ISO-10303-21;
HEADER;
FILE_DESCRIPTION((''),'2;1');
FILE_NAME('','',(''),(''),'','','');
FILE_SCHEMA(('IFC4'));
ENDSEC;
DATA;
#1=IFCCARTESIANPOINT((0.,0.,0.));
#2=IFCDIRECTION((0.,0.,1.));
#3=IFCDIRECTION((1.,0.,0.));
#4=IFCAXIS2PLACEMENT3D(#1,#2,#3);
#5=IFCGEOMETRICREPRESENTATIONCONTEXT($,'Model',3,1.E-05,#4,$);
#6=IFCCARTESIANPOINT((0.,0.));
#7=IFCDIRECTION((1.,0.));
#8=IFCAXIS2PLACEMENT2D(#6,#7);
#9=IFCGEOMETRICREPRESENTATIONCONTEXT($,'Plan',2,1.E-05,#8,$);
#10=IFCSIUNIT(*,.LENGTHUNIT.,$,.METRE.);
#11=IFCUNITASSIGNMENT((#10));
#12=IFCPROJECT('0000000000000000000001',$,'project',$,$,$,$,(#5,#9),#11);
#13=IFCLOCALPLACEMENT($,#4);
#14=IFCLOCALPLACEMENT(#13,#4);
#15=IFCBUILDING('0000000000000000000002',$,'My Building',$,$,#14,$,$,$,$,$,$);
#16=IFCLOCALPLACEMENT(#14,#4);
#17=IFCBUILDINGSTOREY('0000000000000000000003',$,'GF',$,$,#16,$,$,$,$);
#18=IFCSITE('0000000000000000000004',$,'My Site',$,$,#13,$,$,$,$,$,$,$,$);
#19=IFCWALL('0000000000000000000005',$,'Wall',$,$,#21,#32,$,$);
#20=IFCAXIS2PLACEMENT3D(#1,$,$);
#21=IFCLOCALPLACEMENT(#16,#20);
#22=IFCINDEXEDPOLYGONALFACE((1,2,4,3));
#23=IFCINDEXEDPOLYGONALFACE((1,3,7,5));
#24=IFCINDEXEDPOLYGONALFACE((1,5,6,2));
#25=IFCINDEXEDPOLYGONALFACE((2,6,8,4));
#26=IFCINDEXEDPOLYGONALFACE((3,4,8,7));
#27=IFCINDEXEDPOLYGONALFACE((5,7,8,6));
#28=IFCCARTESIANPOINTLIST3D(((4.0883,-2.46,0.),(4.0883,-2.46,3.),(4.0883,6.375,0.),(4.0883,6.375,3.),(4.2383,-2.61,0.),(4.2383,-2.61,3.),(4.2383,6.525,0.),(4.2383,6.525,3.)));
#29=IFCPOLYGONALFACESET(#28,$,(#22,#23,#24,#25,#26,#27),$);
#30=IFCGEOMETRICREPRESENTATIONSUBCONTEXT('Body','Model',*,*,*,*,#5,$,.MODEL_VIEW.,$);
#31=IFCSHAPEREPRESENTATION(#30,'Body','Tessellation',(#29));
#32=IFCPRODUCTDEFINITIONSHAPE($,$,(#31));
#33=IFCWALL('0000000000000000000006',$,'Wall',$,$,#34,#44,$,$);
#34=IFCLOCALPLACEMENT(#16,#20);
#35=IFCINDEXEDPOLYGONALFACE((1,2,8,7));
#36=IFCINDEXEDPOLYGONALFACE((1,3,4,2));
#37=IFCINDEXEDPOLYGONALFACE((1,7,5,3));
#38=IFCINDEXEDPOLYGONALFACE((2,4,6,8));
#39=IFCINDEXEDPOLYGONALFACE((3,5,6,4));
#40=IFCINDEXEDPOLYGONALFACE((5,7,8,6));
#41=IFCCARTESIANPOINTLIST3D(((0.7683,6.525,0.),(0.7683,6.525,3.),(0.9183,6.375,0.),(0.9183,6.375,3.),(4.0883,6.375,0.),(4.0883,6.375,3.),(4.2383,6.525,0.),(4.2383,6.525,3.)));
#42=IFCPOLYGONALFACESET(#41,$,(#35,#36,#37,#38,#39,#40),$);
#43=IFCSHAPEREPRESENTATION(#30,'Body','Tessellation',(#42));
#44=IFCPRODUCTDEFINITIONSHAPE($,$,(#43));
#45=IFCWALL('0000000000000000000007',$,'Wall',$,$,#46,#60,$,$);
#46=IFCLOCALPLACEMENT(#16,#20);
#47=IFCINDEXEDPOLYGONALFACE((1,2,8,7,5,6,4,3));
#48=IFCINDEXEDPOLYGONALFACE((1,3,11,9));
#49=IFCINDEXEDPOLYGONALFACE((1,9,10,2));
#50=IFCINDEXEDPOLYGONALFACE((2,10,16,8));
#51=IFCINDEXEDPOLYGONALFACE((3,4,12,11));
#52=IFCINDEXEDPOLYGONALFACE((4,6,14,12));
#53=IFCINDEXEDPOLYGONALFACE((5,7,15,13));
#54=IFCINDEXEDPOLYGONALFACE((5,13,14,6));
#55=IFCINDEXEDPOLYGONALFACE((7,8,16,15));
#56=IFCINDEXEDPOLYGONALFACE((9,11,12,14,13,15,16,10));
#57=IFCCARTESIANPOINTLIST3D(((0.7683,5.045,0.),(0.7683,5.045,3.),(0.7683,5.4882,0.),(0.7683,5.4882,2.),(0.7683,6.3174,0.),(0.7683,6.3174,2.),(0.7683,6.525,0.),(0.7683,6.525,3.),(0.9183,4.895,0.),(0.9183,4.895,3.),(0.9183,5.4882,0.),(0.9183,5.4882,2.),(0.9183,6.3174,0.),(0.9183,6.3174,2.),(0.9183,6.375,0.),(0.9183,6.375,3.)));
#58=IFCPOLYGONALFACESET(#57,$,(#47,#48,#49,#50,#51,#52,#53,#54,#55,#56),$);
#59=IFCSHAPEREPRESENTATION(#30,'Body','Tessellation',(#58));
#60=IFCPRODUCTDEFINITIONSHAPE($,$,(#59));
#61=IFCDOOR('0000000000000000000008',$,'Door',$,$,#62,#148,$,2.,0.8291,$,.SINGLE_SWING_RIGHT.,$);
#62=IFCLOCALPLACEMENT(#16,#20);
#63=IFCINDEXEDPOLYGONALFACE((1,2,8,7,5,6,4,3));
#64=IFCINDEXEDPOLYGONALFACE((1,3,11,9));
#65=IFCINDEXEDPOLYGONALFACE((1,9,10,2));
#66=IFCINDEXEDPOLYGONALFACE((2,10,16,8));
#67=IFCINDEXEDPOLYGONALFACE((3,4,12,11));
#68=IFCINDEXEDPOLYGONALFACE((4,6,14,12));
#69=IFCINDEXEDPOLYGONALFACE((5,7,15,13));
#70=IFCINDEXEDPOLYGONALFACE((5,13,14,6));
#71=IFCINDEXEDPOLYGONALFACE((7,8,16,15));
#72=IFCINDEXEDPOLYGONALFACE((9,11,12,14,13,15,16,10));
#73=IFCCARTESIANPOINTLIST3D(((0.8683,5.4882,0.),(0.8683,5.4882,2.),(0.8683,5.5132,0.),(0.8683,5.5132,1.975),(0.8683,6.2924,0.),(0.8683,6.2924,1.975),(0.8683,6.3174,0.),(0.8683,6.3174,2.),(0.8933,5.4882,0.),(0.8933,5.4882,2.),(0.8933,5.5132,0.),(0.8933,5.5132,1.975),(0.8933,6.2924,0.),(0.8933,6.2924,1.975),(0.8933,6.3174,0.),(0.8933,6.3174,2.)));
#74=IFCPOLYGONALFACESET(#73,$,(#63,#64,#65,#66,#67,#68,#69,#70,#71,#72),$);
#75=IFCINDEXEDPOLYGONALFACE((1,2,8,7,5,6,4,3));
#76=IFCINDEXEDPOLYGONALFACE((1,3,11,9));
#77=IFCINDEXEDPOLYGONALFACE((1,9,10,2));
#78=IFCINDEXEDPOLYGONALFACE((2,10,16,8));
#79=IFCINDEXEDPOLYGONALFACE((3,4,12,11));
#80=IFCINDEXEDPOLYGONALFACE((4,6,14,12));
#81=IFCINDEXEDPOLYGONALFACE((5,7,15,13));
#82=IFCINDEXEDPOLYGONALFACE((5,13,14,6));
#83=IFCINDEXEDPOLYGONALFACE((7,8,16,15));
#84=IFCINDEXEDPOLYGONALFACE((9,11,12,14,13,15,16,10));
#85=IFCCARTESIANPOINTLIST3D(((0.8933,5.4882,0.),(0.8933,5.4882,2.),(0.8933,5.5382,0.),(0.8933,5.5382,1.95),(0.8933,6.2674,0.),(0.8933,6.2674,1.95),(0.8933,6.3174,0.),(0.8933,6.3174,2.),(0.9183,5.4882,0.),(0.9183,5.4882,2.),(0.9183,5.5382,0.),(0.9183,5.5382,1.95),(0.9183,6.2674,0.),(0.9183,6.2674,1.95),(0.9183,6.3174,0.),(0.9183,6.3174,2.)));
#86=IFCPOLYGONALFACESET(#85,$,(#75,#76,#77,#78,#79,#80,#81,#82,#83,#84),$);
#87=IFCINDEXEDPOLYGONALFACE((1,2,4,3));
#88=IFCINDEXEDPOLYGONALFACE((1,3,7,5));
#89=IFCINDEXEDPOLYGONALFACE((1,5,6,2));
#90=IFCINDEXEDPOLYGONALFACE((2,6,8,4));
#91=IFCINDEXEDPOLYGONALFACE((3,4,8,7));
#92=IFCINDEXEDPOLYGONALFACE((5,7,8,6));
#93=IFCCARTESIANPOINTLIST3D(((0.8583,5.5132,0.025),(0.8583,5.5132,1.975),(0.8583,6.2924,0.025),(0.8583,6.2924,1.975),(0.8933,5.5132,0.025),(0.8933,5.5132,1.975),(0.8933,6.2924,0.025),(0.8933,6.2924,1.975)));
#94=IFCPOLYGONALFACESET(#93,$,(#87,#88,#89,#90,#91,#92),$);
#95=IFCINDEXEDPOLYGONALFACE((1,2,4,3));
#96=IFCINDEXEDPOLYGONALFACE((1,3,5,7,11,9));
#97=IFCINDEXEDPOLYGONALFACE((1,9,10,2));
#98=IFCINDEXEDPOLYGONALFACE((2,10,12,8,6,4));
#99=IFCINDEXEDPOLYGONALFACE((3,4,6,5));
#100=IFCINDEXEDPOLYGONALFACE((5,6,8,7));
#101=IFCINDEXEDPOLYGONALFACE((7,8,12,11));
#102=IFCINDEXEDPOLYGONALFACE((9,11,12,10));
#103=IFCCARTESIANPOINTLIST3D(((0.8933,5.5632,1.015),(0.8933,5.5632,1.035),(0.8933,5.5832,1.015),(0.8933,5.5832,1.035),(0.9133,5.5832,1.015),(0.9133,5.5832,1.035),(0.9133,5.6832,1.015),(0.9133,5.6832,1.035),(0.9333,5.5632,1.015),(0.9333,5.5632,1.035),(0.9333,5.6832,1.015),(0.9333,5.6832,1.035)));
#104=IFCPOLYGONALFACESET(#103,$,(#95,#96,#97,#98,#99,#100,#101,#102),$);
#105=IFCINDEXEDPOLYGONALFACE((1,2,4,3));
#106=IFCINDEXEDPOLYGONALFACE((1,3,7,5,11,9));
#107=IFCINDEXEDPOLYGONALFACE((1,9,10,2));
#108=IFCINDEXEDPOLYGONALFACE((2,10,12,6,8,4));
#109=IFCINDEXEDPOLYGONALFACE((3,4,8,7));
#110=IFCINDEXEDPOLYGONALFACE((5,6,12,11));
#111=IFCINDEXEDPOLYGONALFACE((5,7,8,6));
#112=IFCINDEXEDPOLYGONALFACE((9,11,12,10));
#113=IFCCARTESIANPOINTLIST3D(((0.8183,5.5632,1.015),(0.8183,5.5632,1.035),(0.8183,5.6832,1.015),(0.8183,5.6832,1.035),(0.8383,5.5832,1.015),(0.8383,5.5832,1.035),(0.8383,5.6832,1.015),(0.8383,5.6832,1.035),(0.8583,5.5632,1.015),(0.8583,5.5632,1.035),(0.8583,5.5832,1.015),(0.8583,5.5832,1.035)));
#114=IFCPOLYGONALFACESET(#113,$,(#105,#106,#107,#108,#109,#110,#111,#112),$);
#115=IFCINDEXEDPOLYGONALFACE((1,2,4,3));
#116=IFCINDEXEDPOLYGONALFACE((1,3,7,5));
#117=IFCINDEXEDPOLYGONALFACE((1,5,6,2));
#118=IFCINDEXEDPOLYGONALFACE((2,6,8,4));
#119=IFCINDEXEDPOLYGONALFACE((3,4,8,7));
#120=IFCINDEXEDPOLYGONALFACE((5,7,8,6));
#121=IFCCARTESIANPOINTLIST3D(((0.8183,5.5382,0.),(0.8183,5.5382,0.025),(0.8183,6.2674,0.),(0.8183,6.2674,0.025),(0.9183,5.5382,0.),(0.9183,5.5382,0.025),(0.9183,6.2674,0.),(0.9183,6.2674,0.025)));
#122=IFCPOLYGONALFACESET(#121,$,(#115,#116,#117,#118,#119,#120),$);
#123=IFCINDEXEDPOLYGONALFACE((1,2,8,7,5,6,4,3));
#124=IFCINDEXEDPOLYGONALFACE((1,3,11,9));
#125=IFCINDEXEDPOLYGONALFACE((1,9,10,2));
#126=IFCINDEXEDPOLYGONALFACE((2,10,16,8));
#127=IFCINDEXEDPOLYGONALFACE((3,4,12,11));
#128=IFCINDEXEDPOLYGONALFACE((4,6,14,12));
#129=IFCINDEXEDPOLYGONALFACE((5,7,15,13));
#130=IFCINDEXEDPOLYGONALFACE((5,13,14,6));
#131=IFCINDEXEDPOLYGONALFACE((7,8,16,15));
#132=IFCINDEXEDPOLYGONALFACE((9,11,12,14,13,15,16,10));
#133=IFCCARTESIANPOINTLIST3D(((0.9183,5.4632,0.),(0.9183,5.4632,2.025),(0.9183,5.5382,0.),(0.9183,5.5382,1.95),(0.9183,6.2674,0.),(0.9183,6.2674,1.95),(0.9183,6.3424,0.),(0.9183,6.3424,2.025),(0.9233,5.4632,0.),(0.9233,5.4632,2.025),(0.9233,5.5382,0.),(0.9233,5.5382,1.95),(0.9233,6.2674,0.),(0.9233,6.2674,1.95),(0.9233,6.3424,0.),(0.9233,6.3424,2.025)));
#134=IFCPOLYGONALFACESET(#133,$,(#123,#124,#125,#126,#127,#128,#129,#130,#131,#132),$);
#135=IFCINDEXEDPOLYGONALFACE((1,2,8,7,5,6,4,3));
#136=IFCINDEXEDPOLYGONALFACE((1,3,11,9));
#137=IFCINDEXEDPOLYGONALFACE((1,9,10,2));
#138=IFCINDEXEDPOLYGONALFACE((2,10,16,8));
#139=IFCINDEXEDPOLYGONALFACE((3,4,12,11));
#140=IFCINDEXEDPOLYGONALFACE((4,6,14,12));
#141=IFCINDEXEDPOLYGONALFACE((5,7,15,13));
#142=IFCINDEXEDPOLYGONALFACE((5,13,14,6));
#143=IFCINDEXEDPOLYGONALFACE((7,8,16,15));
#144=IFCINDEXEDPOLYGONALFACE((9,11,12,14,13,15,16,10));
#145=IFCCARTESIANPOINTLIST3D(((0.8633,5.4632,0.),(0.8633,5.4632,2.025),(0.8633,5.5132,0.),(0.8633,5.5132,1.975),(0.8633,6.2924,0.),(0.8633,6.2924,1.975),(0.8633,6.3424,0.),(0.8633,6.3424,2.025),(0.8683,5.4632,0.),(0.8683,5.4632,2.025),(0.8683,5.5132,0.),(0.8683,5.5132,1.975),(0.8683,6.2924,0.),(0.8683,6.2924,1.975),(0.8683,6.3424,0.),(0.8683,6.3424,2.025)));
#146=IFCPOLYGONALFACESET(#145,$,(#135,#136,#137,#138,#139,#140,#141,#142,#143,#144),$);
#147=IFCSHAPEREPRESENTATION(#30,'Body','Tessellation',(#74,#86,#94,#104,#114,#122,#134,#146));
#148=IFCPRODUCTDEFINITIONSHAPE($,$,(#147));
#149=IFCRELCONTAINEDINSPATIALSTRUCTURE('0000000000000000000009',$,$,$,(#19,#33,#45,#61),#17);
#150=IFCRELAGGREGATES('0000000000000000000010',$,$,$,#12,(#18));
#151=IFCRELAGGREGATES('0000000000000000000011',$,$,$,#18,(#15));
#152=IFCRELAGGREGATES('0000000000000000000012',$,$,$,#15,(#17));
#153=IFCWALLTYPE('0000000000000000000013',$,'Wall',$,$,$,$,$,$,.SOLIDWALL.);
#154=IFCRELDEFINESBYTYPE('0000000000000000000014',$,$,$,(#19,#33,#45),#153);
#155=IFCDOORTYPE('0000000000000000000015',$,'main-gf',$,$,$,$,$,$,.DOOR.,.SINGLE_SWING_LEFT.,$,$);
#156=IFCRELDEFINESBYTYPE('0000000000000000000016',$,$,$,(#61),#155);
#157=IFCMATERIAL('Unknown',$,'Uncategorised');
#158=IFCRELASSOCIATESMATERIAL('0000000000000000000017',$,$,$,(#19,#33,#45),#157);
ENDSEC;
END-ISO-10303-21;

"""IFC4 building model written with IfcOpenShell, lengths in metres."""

from ifc_helpers import new_model, entity, si_unit, frame, origin_with_axes, origin_2d_with_axis, place, context, subcontext, project, spatial, line, indexed_curve, outline, extrude, shape, source, transform, mapped, material, type_object, type_shapes, element, fill, save


model = new_model("IFC4")

# Units and contexts
model_context = context("Model", 3, precision=1e-05, world=origin_with_axes())
plan_context = context("Plan", 2, precision=1e-05, world=origin_2d_with_axis())
body_context_1 = subcontext(model_context, "Body", "Model", "MODEL_VIEW")
body_context_2 = subcontext(plan_context, "Body", "Plan", "PLAN_VIEW")
ifc_project = project(units=[si_unit("LENGTHUNIT", "METRE")], contexts=[model_context, plan_context])

# Site, building, storey
site_placement = place(None, origin_with_axes())
site = spatial("IfcSite", under=ifc_project, at=site_placement, Name="My Site")
building_placement = place(site_placement, origin_with_axes())
building = spatial("IfcBuilding", under=site, at=building_placement, Name="My Building")
storey_placement = place(building_placement, origin_with_axes())
storey = spatial("IfcBuildingStorey", under=building, at=storey_placement, Name="GF")

# Shared definitions
ifc_material = material(Name="Unknown", Category="Uncategorised")
wall_type_1 = type_object("IfcWallType", Name="Wall", PredefinedType="SOLIDWALL")
shared_shape_1 = source(origin_with_axes(), body_context_1, "Body", "SweptSolid", [
    extrude(outline(indexed_curve([(0.0, 0.0), (0.8291, 0.0), (0.8291, 2.0), (0.0, 2.0)], segments=[line(1, 2, 3, 4, 1)])), frame((0.0, -0.6, 0.0), z_axis=(0.0, -1.0, 0.0), x_axis=(1.0, 0.0, 0.0)), (0.0, 0.0, -1.0), 1.2),
])
door_type_1 = type_object("IfcDoorType", Name="main-gf", OperationType="SINGLE_SWING_LEFT", PredefinedType="DOOR")
shared_shape_2 = source(origin_with_axes(), body_context_1, "Body", "SweptSolid", [
    extrude(outline(indexed_curve([(0.0, 0.0), (0.0, 2.0), (0.8291, 2.0), (0.8291, 0.0), (0.8041, 0.0), (0.8041, 1.975), (0.025, 1.975), (0.025, 0.0)], segments=[line(1, 2, 3, 4, 5, 6, 7, 8, 1)])), frame((0.0, 0.025, 0.0), z_axis=(0.0, -1.0, 0.0), x_axis=(1.0, 0.0, 0.0)), (0.0, 0.0, -1.0), 0.025),
    extrude(outline(indexed_curve([(0.0, 0.0), (0.0, 2.0), (0.8291, 2.0), (0.8291, 0.0), (0.7791, 0.0), (0.7791, 1.95), (0.05, 1.95), (0.05, 0.0)], segments=[line(1, 2, 3, 4, 5, 6, 7, 8, 1)])), frame((0.0, 0.0, 0.0), z_axis=(0.0, -1.0, 0.0), x_axis=(1.0, 0.0, 0.0)), (0.0, 0.0, -1.0), 0.025),
    extrude(outline(indexed_curve([(0.0, 0.0), (0.7791, 0.0), (0.7791, 0.035), (0.0, 0.035)], segments=[line(1, 2, 3, 4, 1)])), frame((0.025, 0.025, 0.025), z_axis=(0.0, 0.0, 1.0), x_axis=(1.0, 0.0, 0.0)), (0.0, 0.0, 1.0), 1.95),
    extrude(outline(indexed_curve([(0.0, 0.0), (0.0, -0.04), (0.12, -0.04), (0.12, -0.02), (0.02, -0.02), (0.02, 0.0)], segments=[line(1, 2, 3, 4, 5, 6, 1)])), frame((0.075, 0.025, 1.015), z_axis=(0.0, 0.0, 1.0), x_axis=(1.0, 0.0, 0.0)), (0.0, 0.0, 1.0), 0.02),
    extrude(outline(indexed_curve([(0.0, 0.0), (0.0, 0.04), (0.12, 0.04), (0.12, 0.02), (0.02, 0.02), (0.02, 0.0)], segments=[line(1, 2, 3, 4, 5, 6, 1)])), frame((0.075, 0.06, 1.015), z_axis=(0.0, 0.0, 1.0), x_axis=(1.0, 0.0, 0.0)), (0.0, 0.0, 1.0), 0.02),
    extrude(outline(indexed_curve([(0.0, 0.0), (0.7291, 0.0), (0.7291, 0.1), (0.0, 0.1)], segments=[line(1, 2, 3, 4, 1)])), frame((0.05, 0.0, 0.0), z_axis=(0.0, 0.0, 1.0), x_axis=(1.0, 0.0, 0.0)), (0.0, 0.0, 1.0), 0.025),
    extrude(outline(indexed_curve([(0.0, 0.0), (0.0, 2.025), (0.8791, 2.025), (0.8791, 0.0), (0.8041, 0.0), (0.8041, 1.95), (0.075, 1.95), (0.075, 0.0)], segments=[line(1, 2, 3, 4, 5, 6, 7, 8, 1)])), frame((-0.025, -0.005, 0.0), z_axis=(0.0, -1.0, 0.0), x_axis=(1.0, 0.0, 0.0)), (0.0, 0.0, -1.0), 0.005),
    extrude(outline(indexed_curve([(0.0, 0.0), (0.0, 2.025), (0.8791, 2.025), (0.8791, 0.0), (0.8291, 0.0), (0.8291, 1.975), (0.05, 1.975), (0.05, 0.0)], segments=[line(1, 2, 3, 4, 5, 6, 7, 8, 1)])), frame((-0.025, 0.05, 0.0), z_axis=(0.0, -1.0, 0.0), x_axis=(1.0, 0.0, 0.0)), (0.0, 0.0, -1.0), 0.005),
])
shared_shape_3 = source(origin_with_axes(), body_context_2, "Body", "Curve2D", [
    entity("IfcIndexedPolyCurve", entity("IfcCartesianPointList2D", [[0.0, 0.0], [0.0, 0.05], [0.025, 0.05], [0.025, 0.025], [0.05, 0.025], [0.05, 0.0]]), [entity("IfcLineIndex", [1, 2, 3, 4, 5, 6, 1])]),
    entity("IfcIndexedPolyCurve", entity("IfcCartesianPointList2D", [[0.8291, 0.0], [0.8291, 0.05], [0.8041, 0.05], [0.8041, 0.025], [0.7791, 0.025], [0.7791, 0.0]]), [entity("IfcLineIndex", [1, 2, 3, 4, 5, 6, 1])]),
    entity("IfcTrimmedCurve", entity("IfcEllipse", entity("IfcAxis2Placement2D", entity("IfcCartesianPoint", [0.7691, 0.05]), entity("IfcDirection", [1.0, 0.0])), 0.7441, 0.7791), [entity("IfcCartesianPoint", [0.7691, 0.8291])], [entity("IfcCartesianPoint", [0.025, 0.05])], True, "CARTESIAN"),
    entity("IfcIndexedPolyCurve", entity("IfcCartesianPointList2D", [[0.8041, 0.05], [0.7691, 0.05], [0.7691, 0.8291], [0.8041, 0.8291]]), [entity("IfcLineIndex", [1, 2, 3, 4, 1])]),
])
type_shapes(door_type_1, [shared_shape_2, shared_shape_3])

# Walls
wall_1_placement = place(storey_placement, frame((4.2383, -2.61, 0.0), z_axis=(0.0, 0.0, 1.0), x_axis=(0.0, 1.0, 0.0)))
element("IfcWall", 1, at=wall_1_placement, inside=storey, type_object=wall_type_1, material=ifc_material, Name="Wall", context=body_context_1, shape_type="SweptSolid", body=[
    extrude(outline(indexed_curve([(0.0, 0.0), (0.15, 0.15), (8.985, 0.15), (9.135, 0.0)], segments=[line(1, 2, 3, 4, 1)])), origin_with_axes(), (0.0, 0.0, 1.0), 3.0),
])
wall_2_placement = place(storey_placement, frame((4.2383, 6.525, 0.0), z_axis=(0.0, 0.0, 1.0), x_axis=(-1.0, 0.0, 0.0)))
element("IfcWall", 2, at=wall_2_placement, inside=storey, type_object=wall_type_1, material=ifc_material, Name="Wall", context=body_context_1, shape_type="SweptSolid", body=[
    extrude(outline(indexed_curve([(0.0, 0.0), (0.15, 0.15), (3.32, 0.15), (3.47, 0.0)], segments=[line(1, 2, 3, 4, 1)])), origin_with_axes(), (0.0, 0.0, 1.0), 3.0),
])

# Wall, opening, door
wall_3_placement = place(storey_placement, frame((0.7683, 6.525, 0.0), z_axis=(0.0, 0.0, 1.0), x_axis=(0.0, -1.0, 0.0)))
wall_3 = element("IfcWall", 3, at=wall_3_placement, inside=storey, type_object=wall_type_1, material=ifc_material, Name="Wall", context=body_context_1, shape_type="SweptSolid", body=[
    extrude(outline(indexed_curve([(0.0, 0.0), (0.15, 0.15), (1.63, 0.15), (1.48, 0.0)], segments=[line(1, 2, 3, 4, 1)])), origin_with_axes(), (0.0, 0.0, 1.0), 3.0),
])
opening_1_placement = place(wall_3_placement, frame((1.0368, 0.15, 0.0), z_axis=(0.0, 0.0, 1.0), x_axis=(-1.0, 0.0, 0.0)))
opening_1 = element("IfcOpeningElement", 4, at=opening_1_placement, cuts=wall_3, PredefinedType="OPENING", context=body_context_1, shape_type="MappedRepresentation", body=[
    mapped(shared_shape_1, transform((0.0, 0.0, 0.0), x_axis=(1.0, 0.0, 0.0), y_axis=(0.0, 1.0, 0.0), z_axis=(0.0, 0.0, 1.0), scale=1.0)),
])
door_1_placement = place(opening_1_placement, frame((0.0, 0.0, 0.0), z_axis=(0.0, 0.0, 1.0), x_axis=(1.0, 0.0, 0.0)))
door_1 = element("IfcDoor", 5, at=door_1_placement, inside=storey, type_object=door_type_1, Name="Door", OperationType="SINGLE_SWING_RIGHT", OverallHeight=2.0, OverallWidth=0.8291, shapes=[
    shape(body_context_1, "Body", "MappedRepresentation", [mapped(shared_shape_2, transform((0.0, 0.0, 0.0), x_axis=(1.0, 0.0, 0.0), y_axis=(0.0, 1.0, 0.0), z_axis=(0.0, 0.0, 1.0), scale=1.0))]),
    shape(body_context_2, "Body", "MappedRepresentation", [mapped(shared_shape_3, transform((0.0, 0.0, 0.0), x_axis=(1.0, 0.0, 0.0), y_axis=(0.0, 1.0, 0.0), z_axis=(0.0, 0.0, 1.0), scale=1.0))]),
])
fill(opening_1, door_1)

save(model, "model.ifc")
